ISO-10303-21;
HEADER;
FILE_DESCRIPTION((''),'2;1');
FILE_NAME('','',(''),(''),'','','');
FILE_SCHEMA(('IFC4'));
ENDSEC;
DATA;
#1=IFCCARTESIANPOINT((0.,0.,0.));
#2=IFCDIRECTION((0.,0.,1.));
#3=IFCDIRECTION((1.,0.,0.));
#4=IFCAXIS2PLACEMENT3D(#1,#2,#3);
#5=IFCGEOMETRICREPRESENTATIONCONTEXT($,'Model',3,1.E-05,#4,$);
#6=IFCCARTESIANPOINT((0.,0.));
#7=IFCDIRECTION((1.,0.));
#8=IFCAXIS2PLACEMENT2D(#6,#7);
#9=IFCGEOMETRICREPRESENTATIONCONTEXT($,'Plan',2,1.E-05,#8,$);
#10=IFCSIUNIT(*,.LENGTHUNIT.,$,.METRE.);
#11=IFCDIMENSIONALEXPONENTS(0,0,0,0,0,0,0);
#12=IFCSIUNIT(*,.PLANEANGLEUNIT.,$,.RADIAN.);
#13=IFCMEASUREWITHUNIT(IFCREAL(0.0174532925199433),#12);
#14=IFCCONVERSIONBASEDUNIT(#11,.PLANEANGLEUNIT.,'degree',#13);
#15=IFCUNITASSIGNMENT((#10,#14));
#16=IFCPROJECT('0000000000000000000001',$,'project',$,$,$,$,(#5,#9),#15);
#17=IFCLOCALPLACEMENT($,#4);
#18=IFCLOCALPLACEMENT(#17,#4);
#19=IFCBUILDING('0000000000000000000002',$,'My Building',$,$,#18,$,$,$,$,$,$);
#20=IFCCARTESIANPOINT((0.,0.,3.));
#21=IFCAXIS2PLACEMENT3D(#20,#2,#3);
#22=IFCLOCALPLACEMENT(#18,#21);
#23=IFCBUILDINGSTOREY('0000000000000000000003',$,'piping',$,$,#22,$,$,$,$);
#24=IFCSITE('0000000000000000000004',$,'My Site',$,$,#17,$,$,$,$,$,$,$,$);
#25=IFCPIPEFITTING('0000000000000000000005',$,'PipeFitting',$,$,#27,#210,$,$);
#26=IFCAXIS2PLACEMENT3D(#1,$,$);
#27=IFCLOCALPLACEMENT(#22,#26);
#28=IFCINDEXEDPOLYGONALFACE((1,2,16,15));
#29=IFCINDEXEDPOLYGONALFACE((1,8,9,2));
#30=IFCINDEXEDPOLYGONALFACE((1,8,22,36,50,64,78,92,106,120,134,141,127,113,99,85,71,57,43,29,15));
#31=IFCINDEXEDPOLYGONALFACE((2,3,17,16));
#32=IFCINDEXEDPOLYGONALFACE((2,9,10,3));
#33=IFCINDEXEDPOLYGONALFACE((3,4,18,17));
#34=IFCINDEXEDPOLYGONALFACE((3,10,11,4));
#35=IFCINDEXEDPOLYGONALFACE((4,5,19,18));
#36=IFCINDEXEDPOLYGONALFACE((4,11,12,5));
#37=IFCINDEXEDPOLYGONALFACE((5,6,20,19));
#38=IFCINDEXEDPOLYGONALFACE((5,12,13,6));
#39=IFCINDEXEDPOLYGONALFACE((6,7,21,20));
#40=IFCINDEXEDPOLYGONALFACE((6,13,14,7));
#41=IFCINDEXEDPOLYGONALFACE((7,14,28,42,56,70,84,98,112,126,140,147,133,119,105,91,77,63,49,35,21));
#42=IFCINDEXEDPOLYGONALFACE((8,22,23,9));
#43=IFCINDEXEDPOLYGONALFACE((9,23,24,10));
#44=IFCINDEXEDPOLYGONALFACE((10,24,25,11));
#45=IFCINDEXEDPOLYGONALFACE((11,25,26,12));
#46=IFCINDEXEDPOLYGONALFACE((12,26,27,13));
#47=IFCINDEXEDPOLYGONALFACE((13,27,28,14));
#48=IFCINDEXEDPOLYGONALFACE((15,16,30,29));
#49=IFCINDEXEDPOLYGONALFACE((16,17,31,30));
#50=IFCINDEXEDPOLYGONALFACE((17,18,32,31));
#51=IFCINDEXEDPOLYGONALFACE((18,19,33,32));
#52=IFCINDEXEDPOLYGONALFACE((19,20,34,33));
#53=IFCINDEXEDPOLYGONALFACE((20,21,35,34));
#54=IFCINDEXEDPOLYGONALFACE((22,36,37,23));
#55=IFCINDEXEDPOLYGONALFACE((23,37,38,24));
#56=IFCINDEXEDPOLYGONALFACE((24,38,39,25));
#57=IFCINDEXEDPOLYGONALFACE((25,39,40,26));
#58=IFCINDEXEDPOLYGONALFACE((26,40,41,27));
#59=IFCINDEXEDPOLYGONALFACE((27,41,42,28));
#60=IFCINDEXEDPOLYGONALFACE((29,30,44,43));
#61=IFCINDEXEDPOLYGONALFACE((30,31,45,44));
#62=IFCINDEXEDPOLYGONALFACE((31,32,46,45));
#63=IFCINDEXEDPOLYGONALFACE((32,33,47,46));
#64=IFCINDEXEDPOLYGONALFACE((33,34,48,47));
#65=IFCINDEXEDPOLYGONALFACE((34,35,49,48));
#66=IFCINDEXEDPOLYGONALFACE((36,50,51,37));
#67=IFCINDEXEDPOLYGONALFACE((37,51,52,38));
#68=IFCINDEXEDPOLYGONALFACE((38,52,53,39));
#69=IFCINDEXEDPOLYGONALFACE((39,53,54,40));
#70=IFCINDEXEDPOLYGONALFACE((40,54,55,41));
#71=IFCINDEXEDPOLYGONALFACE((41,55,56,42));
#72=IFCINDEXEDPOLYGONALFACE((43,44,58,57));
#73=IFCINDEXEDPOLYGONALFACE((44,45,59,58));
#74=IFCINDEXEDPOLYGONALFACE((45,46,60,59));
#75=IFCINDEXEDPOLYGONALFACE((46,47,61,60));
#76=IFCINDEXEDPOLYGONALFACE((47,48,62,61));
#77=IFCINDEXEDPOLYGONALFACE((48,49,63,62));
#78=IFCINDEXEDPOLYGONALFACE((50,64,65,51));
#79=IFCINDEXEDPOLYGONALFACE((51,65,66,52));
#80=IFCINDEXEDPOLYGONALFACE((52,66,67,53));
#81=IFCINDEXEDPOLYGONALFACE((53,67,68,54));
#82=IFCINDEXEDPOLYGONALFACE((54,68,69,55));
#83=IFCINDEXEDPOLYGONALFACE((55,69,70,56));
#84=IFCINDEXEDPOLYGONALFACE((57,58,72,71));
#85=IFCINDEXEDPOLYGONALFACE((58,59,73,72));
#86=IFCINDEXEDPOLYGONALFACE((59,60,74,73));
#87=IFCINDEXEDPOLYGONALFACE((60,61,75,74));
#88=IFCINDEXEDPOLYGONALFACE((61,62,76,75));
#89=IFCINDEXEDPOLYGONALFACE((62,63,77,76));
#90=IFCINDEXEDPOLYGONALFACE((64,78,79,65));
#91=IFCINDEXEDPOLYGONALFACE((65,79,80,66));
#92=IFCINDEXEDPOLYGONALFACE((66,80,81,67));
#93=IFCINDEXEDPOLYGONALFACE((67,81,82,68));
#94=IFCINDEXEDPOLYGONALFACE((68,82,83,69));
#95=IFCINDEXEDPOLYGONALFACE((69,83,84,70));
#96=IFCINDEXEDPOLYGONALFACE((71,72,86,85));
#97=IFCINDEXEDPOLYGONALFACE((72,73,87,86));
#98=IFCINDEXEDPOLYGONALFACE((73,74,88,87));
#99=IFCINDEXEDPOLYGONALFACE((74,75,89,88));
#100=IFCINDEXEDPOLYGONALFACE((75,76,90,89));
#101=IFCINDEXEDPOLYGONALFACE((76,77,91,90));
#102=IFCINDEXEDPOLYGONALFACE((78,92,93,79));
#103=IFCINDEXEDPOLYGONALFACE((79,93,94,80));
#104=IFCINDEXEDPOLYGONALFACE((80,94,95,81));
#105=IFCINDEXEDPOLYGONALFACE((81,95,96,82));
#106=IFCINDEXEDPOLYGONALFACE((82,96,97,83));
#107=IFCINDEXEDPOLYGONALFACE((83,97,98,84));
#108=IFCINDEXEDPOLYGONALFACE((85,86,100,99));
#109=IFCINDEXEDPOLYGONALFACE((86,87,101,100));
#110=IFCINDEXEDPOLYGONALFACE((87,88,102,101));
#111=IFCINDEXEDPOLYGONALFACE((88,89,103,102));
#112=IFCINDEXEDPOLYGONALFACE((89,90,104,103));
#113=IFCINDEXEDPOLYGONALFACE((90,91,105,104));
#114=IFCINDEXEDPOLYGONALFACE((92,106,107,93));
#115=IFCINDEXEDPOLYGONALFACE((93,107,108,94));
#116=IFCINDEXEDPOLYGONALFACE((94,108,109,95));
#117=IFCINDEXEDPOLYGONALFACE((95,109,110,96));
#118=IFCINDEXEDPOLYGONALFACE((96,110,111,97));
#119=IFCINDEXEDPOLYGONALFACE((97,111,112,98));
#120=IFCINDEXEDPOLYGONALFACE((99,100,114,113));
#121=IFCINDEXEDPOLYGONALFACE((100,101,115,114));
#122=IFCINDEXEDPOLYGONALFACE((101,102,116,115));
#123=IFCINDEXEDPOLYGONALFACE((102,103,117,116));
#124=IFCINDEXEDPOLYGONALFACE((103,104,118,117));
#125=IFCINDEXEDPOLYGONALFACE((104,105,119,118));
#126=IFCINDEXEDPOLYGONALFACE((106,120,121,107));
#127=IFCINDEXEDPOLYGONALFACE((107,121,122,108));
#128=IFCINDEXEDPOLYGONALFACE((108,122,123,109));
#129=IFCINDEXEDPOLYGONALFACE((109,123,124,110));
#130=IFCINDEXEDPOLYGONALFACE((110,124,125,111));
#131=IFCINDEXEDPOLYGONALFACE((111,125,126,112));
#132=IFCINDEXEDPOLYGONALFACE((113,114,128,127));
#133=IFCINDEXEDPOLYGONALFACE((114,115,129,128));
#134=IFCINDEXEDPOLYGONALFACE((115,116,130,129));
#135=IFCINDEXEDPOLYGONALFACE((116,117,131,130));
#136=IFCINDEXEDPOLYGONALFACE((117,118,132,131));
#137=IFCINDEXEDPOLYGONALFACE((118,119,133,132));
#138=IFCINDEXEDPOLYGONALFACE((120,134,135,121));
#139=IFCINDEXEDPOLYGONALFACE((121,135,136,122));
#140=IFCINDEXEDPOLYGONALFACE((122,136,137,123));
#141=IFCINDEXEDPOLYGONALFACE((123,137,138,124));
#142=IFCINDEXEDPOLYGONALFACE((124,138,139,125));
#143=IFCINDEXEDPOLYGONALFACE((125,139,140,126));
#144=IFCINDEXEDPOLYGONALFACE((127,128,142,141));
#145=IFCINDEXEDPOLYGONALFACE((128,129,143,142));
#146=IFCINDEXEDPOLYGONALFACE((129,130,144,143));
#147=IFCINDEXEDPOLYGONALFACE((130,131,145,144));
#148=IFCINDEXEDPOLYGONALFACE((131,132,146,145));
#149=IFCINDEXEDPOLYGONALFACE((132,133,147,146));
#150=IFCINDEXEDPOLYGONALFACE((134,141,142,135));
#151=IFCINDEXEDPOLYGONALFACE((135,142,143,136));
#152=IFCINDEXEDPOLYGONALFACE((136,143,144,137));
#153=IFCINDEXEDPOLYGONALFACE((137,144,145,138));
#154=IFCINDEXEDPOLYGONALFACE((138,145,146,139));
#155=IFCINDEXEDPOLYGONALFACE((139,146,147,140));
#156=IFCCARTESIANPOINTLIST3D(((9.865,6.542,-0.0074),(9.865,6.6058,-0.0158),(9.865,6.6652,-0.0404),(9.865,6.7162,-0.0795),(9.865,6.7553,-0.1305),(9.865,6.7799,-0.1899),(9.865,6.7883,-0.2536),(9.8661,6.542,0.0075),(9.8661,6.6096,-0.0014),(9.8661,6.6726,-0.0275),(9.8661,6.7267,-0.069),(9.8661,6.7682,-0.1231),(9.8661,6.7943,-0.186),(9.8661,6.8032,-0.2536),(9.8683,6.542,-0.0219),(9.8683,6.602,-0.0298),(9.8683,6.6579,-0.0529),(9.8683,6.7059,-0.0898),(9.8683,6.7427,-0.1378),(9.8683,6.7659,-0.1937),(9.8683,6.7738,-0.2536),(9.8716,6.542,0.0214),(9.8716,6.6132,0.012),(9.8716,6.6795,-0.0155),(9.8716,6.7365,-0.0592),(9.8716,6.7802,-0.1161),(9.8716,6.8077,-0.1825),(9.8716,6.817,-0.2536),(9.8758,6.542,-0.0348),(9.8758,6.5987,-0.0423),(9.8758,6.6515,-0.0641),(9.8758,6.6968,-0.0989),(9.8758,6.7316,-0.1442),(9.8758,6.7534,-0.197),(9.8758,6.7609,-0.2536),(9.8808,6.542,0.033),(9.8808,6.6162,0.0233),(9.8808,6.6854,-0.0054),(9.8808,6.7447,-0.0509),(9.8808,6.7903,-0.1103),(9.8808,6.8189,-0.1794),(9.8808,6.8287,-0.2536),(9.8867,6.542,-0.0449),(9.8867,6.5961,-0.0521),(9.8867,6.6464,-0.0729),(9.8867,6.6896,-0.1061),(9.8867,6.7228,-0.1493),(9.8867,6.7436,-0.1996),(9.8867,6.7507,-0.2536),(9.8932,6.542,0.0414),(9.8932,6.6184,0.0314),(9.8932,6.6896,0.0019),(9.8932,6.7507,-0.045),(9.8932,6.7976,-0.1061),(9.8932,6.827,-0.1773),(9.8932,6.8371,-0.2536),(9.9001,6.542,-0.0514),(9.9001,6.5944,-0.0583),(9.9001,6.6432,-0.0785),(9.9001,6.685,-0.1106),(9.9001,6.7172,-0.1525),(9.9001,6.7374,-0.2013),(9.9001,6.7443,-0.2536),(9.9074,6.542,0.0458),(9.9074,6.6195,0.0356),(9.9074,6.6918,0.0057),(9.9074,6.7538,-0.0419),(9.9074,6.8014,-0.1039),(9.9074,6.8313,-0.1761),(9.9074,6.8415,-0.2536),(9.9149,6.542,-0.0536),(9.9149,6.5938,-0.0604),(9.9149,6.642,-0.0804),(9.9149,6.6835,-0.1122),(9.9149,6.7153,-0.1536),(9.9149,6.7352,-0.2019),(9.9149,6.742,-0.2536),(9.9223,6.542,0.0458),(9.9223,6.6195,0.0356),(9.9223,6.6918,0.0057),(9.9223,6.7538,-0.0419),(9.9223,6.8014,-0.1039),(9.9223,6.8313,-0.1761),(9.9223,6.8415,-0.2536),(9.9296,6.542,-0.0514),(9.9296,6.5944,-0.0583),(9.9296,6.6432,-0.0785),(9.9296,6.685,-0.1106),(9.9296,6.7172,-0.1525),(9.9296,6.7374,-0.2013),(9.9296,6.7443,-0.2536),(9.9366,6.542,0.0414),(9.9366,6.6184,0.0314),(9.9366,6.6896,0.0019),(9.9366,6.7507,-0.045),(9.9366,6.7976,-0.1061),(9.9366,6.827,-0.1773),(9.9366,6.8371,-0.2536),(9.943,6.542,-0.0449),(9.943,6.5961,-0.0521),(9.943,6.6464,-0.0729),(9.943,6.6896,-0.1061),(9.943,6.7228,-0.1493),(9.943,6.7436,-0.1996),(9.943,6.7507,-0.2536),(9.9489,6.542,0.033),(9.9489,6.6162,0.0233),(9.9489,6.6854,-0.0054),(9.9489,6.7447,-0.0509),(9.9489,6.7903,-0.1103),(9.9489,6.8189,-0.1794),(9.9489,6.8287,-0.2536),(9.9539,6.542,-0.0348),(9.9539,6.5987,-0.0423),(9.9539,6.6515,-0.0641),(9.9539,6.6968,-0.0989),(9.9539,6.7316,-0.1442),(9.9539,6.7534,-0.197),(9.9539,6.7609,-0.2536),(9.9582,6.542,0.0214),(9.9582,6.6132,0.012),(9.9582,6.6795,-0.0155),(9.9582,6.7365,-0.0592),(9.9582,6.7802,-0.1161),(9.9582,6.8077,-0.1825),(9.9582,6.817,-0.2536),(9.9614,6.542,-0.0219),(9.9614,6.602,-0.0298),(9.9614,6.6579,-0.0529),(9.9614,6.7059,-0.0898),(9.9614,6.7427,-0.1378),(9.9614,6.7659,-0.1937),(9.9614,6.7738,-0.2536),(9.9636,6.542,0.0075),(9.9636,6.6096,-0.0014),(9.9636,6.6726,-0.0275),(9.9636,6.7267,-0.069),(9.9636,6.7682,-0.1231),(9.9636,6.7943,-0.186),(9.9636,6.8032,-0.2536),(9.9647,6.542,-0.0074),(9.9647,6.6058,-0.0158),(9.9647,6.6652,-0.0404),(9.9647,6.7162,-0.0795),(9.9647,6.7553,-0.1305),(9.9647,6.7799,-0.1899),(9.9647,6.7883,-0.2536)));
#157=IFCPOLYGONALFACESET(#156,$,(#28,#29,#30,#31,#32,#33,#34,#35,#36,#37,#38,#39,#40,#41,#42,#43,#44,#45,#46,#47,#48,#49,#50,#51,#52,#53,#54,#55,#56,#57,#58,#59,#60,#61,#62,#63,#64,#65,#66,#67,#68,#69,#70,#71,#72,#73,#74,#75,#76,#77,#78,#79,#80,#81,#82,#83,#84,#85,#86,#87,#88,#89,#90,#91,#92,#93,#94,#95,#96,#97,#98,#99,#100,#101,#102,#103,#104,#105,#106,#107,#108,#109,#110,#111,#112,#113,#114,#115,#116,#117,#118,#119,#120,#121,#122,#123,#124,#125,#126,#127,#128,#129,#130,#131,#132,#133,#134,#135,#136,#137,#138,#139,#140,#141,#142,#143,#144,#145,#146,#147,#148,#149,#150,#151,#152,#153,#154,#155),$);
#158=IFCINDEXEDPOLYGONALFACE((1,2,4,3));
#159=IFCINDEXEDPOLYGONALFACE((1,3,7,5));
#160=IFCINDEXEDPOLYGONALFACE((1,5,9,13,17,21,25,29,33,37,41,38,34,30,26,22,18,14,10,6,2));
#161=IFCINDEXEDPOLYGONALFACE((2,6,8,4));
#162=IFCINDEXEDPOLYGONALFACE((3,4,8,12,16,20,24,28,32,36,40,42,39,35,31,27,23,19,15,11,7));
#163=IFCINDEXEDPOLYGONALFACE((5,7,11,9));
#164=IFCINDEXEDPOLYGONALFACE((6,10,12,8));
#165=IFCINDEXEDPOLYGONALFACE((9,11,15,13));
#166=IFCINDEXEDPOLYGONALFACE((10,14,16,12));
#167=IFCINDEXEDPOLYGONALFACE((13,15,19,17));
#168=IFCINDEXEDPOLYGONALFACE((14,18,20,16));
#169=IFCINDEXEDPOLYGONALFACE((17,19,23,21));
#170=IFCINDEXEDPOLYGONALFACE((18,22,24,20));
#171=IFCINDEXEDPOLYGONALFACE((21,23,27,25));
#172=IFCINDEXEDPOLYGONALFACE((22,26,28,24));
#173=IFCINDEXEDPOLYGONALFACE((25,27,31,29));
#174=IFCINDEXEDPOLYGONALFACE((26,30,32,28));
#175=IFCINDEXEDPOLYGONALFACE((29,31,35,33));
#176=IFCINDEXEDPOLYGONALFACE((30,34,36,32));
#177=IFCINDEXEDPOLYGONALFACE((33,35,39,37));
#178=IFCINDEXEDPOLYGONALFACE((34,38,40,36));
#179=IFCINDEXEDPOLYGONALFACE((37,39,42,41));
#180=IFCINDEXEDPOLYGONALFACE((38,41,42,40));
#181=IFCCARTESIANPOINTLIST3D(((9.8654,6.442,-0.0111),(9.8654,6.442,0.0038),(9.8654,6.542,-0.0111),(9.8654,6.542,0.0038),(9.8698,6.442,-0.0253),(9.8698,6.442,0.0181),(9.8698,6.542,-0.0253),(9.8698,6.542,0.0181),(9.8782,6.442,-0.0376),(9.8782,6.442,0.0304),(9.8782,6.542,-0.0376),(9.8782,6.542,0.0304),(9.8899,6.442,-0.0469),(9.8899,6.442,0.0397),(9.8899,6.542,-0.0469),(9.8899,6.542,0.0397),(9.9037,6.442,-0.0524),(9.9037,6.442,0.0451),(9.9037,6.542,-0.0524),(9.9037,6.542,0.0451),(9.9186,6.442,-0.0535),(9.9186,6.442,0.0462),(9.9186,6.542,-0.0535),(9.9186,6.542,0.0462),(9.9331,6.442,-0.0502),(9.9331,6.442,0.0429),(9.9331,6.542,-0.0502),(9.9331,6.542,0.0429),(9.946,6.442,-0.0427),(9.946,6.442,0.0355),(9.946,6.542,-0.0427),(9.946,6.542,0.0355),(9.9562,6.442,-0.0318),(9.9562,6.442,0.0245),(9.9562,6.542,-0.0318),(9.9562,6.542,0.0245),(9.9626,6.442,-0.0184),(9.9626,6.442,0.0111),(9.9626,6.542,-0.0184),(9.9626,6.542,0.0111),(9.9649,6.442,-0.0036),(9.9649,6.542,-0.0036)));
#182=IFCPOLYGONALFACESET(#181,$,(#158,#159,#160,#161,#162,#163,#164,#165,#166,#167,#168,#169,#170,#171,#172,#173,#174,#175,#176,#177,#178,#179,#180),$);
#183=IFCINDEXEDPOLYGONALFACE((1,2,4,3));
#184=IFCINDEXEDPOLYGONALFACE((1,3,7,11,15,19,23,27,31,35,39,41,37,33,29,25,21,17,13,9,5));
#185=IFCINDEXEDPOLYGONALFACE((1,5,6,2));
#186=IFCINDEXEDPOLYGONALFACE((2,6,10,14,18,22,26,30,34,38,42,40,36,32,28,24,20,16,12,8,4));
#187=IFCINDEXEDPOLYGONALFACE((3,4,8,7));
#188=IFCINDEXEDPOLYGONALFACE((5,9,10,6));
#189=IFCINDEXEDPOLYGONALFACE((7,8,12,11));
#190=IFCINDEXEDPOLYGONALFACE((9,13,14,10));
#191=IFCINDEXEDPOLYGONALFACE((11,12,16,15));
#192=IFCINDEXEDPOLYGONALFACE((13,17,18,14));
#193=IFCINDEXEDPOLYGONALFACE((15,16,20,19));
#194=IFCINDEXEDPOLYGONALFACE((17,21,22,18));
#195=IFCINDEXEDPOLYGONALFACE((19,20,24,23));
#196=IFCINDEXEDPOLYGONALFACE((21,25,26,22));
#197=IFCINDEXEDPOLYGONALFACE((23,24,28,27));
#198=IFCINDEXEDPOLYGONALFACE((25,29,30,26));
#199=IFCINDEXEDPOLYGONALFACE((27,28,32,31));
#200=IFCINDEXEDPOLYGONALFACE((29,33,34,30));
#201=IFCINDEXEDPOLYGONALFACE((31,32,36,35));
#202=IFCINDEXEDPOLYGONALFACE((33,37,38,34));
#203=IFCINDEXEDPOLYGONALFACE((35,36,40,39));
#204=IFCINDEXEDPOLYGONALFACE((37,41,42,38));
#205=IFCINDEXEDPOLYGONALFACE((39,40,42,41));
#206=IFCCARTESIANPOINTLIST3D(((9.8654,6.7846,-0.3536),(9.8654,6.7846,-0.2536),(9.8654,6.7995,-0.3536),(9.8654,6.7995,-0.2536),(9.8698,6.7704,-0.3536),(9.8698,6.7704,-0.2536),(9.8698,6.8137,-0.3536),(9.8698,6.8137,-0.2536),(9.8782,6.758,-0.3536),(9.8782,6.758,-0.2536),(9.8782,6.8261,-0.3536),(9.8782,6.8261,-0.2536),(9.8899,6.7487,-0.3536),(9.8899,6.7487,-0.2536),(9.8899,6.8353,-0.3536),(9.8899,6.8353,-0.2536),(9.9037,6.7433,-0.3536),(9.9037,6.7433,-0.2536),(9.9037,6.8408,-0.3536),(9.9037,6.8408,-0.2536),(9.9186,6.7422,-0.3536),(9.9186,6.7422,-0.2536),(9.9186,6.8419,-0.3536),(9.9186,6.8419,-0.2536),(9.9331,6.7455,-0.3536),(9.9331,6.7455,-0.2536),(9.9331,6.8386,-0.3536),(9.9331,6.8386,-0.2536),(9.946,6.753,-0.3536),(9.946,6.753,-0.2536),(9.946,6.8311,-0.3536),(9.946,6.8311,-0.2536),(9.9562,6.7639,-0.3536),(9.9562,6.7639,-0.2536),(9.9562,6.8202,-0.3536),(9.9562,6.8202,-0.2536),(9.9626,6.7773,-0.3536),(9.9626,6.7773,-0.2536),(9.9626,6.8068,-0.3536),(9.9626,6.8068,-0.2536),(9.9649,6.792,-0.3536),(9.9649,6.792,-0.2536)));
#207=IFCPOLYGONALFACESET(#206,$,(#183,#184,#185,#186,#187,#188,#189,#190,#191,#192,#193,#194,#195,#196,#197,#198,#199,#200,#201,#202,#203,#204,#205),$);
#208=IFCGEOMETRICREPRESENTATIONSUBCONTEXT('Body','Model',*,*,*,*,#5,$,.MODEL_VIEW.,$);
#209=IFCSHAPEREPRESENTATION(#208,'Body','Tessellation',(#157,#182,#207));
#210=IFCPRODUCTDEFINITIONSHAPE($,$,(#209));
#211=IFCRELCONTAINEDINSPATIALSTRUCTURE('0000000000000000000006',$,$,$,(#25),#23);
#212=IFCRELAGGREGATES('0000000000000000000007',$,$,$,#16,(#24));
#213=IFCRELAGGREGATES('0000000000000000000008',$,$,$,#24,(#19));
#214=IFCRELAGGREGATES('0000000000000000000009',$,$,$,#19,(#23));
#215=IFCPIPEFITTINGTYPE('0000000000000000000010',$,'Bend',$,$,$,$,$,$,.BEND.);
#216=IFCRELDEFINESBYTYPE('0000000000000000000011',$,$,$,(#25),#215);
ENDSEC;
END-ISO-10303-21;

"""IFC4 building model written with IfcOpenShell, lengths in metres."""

from ifc_helpers import new_model, entity, si_unit, converted_unit, frame, origin_with_axes, origin_2d_with_axis, place, context, subcontext, project, spatial, circle, extrude, source, transform, mapped, type_object, type_shapes, element, save


model = new_model("IFC4")

# Units and contexts
model_context = context("Model", 3, precision=1e-05, world=origin_with_axes())
plan_context = context("Plan", 2, precision=1e-05, world=origin_2d_with_axis())
body_context = subcontext(model_context, "Body", "Model", "MODEL_VIEW")
ifc_project = project(units=[si_unit("LENGTHUNIT", "METRE"), converted_unit("PLANEANGLEUNIT", "degree", entity("IfcReal", 0.0174532925199433), si_unit("PLANEANGLEUNIT", "RADIAN"), dimensions=[0, 0, 0, 0, 0, 0, 0])], contexts=[model_context, plan_context])

# Site, building, storey
site_placement = place(None, origin_with_axes())
site = spatial("IfcSite", under=ifc_project, at=site_placement, Name="My Site")
building_placement = place(site_placement, origin_with_axes())
building = spatial("IfcBuilding", under=site, at=building_placement, Name="My Building")
storey_placement = place(building_placement, frame((0.0, 0.0, 3.0), z_axis=(0.0, 0.0, 1.0), x_axis=(1.0, 0.0, 0.0)))
storey = spatial("IfcBuildingStorey", under=building, at=storey_placement, Name="piping")

# Pipe fitting
pipe_fitting_type = type_object("IfcPipeFittingType", Name="Bend", PredefinedType="BEND")
shared_shape = source(origin_with_axes(), body_context, "Body", "SolidModel", [
    entity("IfcSweptDiskSolid", entity("IfcIndexedPolyCurve", entity("IfcCartesianPointList3D", [[0.0, 0.0, -0.1], [0.0, -0.0732, -0.2768], [0.0, -0.25, -0.35]]), [entity("IfcArcIndex", [1, 2, 3])]), 0.05),
    extrude(circle(Radius=0.05), origin_with_axes(), (0.0, 0.0, -1.0), 0.1),
    extrude(circle(Radius=0.05), frame((0.0, -0.25, -0.35), z_axis=(0.0, -1.0, 0.0), x_axis=(1.0, 0.0, 0.0)), (0.0, 0.0, 1.0), 0.1),
])
type_shapes(pipe_fitting_type, [shared_shape])
for number, where, z_axis, x_axis, name in (
    (1, (9.9149, 6.442, -0.0036), (0.0, -1.0, 0.0), (1.0, 0.0, 0.0), "PipeFitting"),
):
    element("IfcPipeFitting", number, at=place(storey_placement, frame(where, z_axis=z_axis, x_axis=x_axis)), inside=storey, type_object=pipe_fitting_type, Name=name, context=body_context, shape_type="MappedRepresentation", body=[
        mapped(shared_shape, transform((0.0, 0.0, 0.0), x_axis=(1.0, 0.0, 0.0), y_axis=(0.0, 1.0, 0.0), z_axis=(0.0, 0.0, 1.0), scale=1.0)),
    ])

save(model, "model.ifc")
